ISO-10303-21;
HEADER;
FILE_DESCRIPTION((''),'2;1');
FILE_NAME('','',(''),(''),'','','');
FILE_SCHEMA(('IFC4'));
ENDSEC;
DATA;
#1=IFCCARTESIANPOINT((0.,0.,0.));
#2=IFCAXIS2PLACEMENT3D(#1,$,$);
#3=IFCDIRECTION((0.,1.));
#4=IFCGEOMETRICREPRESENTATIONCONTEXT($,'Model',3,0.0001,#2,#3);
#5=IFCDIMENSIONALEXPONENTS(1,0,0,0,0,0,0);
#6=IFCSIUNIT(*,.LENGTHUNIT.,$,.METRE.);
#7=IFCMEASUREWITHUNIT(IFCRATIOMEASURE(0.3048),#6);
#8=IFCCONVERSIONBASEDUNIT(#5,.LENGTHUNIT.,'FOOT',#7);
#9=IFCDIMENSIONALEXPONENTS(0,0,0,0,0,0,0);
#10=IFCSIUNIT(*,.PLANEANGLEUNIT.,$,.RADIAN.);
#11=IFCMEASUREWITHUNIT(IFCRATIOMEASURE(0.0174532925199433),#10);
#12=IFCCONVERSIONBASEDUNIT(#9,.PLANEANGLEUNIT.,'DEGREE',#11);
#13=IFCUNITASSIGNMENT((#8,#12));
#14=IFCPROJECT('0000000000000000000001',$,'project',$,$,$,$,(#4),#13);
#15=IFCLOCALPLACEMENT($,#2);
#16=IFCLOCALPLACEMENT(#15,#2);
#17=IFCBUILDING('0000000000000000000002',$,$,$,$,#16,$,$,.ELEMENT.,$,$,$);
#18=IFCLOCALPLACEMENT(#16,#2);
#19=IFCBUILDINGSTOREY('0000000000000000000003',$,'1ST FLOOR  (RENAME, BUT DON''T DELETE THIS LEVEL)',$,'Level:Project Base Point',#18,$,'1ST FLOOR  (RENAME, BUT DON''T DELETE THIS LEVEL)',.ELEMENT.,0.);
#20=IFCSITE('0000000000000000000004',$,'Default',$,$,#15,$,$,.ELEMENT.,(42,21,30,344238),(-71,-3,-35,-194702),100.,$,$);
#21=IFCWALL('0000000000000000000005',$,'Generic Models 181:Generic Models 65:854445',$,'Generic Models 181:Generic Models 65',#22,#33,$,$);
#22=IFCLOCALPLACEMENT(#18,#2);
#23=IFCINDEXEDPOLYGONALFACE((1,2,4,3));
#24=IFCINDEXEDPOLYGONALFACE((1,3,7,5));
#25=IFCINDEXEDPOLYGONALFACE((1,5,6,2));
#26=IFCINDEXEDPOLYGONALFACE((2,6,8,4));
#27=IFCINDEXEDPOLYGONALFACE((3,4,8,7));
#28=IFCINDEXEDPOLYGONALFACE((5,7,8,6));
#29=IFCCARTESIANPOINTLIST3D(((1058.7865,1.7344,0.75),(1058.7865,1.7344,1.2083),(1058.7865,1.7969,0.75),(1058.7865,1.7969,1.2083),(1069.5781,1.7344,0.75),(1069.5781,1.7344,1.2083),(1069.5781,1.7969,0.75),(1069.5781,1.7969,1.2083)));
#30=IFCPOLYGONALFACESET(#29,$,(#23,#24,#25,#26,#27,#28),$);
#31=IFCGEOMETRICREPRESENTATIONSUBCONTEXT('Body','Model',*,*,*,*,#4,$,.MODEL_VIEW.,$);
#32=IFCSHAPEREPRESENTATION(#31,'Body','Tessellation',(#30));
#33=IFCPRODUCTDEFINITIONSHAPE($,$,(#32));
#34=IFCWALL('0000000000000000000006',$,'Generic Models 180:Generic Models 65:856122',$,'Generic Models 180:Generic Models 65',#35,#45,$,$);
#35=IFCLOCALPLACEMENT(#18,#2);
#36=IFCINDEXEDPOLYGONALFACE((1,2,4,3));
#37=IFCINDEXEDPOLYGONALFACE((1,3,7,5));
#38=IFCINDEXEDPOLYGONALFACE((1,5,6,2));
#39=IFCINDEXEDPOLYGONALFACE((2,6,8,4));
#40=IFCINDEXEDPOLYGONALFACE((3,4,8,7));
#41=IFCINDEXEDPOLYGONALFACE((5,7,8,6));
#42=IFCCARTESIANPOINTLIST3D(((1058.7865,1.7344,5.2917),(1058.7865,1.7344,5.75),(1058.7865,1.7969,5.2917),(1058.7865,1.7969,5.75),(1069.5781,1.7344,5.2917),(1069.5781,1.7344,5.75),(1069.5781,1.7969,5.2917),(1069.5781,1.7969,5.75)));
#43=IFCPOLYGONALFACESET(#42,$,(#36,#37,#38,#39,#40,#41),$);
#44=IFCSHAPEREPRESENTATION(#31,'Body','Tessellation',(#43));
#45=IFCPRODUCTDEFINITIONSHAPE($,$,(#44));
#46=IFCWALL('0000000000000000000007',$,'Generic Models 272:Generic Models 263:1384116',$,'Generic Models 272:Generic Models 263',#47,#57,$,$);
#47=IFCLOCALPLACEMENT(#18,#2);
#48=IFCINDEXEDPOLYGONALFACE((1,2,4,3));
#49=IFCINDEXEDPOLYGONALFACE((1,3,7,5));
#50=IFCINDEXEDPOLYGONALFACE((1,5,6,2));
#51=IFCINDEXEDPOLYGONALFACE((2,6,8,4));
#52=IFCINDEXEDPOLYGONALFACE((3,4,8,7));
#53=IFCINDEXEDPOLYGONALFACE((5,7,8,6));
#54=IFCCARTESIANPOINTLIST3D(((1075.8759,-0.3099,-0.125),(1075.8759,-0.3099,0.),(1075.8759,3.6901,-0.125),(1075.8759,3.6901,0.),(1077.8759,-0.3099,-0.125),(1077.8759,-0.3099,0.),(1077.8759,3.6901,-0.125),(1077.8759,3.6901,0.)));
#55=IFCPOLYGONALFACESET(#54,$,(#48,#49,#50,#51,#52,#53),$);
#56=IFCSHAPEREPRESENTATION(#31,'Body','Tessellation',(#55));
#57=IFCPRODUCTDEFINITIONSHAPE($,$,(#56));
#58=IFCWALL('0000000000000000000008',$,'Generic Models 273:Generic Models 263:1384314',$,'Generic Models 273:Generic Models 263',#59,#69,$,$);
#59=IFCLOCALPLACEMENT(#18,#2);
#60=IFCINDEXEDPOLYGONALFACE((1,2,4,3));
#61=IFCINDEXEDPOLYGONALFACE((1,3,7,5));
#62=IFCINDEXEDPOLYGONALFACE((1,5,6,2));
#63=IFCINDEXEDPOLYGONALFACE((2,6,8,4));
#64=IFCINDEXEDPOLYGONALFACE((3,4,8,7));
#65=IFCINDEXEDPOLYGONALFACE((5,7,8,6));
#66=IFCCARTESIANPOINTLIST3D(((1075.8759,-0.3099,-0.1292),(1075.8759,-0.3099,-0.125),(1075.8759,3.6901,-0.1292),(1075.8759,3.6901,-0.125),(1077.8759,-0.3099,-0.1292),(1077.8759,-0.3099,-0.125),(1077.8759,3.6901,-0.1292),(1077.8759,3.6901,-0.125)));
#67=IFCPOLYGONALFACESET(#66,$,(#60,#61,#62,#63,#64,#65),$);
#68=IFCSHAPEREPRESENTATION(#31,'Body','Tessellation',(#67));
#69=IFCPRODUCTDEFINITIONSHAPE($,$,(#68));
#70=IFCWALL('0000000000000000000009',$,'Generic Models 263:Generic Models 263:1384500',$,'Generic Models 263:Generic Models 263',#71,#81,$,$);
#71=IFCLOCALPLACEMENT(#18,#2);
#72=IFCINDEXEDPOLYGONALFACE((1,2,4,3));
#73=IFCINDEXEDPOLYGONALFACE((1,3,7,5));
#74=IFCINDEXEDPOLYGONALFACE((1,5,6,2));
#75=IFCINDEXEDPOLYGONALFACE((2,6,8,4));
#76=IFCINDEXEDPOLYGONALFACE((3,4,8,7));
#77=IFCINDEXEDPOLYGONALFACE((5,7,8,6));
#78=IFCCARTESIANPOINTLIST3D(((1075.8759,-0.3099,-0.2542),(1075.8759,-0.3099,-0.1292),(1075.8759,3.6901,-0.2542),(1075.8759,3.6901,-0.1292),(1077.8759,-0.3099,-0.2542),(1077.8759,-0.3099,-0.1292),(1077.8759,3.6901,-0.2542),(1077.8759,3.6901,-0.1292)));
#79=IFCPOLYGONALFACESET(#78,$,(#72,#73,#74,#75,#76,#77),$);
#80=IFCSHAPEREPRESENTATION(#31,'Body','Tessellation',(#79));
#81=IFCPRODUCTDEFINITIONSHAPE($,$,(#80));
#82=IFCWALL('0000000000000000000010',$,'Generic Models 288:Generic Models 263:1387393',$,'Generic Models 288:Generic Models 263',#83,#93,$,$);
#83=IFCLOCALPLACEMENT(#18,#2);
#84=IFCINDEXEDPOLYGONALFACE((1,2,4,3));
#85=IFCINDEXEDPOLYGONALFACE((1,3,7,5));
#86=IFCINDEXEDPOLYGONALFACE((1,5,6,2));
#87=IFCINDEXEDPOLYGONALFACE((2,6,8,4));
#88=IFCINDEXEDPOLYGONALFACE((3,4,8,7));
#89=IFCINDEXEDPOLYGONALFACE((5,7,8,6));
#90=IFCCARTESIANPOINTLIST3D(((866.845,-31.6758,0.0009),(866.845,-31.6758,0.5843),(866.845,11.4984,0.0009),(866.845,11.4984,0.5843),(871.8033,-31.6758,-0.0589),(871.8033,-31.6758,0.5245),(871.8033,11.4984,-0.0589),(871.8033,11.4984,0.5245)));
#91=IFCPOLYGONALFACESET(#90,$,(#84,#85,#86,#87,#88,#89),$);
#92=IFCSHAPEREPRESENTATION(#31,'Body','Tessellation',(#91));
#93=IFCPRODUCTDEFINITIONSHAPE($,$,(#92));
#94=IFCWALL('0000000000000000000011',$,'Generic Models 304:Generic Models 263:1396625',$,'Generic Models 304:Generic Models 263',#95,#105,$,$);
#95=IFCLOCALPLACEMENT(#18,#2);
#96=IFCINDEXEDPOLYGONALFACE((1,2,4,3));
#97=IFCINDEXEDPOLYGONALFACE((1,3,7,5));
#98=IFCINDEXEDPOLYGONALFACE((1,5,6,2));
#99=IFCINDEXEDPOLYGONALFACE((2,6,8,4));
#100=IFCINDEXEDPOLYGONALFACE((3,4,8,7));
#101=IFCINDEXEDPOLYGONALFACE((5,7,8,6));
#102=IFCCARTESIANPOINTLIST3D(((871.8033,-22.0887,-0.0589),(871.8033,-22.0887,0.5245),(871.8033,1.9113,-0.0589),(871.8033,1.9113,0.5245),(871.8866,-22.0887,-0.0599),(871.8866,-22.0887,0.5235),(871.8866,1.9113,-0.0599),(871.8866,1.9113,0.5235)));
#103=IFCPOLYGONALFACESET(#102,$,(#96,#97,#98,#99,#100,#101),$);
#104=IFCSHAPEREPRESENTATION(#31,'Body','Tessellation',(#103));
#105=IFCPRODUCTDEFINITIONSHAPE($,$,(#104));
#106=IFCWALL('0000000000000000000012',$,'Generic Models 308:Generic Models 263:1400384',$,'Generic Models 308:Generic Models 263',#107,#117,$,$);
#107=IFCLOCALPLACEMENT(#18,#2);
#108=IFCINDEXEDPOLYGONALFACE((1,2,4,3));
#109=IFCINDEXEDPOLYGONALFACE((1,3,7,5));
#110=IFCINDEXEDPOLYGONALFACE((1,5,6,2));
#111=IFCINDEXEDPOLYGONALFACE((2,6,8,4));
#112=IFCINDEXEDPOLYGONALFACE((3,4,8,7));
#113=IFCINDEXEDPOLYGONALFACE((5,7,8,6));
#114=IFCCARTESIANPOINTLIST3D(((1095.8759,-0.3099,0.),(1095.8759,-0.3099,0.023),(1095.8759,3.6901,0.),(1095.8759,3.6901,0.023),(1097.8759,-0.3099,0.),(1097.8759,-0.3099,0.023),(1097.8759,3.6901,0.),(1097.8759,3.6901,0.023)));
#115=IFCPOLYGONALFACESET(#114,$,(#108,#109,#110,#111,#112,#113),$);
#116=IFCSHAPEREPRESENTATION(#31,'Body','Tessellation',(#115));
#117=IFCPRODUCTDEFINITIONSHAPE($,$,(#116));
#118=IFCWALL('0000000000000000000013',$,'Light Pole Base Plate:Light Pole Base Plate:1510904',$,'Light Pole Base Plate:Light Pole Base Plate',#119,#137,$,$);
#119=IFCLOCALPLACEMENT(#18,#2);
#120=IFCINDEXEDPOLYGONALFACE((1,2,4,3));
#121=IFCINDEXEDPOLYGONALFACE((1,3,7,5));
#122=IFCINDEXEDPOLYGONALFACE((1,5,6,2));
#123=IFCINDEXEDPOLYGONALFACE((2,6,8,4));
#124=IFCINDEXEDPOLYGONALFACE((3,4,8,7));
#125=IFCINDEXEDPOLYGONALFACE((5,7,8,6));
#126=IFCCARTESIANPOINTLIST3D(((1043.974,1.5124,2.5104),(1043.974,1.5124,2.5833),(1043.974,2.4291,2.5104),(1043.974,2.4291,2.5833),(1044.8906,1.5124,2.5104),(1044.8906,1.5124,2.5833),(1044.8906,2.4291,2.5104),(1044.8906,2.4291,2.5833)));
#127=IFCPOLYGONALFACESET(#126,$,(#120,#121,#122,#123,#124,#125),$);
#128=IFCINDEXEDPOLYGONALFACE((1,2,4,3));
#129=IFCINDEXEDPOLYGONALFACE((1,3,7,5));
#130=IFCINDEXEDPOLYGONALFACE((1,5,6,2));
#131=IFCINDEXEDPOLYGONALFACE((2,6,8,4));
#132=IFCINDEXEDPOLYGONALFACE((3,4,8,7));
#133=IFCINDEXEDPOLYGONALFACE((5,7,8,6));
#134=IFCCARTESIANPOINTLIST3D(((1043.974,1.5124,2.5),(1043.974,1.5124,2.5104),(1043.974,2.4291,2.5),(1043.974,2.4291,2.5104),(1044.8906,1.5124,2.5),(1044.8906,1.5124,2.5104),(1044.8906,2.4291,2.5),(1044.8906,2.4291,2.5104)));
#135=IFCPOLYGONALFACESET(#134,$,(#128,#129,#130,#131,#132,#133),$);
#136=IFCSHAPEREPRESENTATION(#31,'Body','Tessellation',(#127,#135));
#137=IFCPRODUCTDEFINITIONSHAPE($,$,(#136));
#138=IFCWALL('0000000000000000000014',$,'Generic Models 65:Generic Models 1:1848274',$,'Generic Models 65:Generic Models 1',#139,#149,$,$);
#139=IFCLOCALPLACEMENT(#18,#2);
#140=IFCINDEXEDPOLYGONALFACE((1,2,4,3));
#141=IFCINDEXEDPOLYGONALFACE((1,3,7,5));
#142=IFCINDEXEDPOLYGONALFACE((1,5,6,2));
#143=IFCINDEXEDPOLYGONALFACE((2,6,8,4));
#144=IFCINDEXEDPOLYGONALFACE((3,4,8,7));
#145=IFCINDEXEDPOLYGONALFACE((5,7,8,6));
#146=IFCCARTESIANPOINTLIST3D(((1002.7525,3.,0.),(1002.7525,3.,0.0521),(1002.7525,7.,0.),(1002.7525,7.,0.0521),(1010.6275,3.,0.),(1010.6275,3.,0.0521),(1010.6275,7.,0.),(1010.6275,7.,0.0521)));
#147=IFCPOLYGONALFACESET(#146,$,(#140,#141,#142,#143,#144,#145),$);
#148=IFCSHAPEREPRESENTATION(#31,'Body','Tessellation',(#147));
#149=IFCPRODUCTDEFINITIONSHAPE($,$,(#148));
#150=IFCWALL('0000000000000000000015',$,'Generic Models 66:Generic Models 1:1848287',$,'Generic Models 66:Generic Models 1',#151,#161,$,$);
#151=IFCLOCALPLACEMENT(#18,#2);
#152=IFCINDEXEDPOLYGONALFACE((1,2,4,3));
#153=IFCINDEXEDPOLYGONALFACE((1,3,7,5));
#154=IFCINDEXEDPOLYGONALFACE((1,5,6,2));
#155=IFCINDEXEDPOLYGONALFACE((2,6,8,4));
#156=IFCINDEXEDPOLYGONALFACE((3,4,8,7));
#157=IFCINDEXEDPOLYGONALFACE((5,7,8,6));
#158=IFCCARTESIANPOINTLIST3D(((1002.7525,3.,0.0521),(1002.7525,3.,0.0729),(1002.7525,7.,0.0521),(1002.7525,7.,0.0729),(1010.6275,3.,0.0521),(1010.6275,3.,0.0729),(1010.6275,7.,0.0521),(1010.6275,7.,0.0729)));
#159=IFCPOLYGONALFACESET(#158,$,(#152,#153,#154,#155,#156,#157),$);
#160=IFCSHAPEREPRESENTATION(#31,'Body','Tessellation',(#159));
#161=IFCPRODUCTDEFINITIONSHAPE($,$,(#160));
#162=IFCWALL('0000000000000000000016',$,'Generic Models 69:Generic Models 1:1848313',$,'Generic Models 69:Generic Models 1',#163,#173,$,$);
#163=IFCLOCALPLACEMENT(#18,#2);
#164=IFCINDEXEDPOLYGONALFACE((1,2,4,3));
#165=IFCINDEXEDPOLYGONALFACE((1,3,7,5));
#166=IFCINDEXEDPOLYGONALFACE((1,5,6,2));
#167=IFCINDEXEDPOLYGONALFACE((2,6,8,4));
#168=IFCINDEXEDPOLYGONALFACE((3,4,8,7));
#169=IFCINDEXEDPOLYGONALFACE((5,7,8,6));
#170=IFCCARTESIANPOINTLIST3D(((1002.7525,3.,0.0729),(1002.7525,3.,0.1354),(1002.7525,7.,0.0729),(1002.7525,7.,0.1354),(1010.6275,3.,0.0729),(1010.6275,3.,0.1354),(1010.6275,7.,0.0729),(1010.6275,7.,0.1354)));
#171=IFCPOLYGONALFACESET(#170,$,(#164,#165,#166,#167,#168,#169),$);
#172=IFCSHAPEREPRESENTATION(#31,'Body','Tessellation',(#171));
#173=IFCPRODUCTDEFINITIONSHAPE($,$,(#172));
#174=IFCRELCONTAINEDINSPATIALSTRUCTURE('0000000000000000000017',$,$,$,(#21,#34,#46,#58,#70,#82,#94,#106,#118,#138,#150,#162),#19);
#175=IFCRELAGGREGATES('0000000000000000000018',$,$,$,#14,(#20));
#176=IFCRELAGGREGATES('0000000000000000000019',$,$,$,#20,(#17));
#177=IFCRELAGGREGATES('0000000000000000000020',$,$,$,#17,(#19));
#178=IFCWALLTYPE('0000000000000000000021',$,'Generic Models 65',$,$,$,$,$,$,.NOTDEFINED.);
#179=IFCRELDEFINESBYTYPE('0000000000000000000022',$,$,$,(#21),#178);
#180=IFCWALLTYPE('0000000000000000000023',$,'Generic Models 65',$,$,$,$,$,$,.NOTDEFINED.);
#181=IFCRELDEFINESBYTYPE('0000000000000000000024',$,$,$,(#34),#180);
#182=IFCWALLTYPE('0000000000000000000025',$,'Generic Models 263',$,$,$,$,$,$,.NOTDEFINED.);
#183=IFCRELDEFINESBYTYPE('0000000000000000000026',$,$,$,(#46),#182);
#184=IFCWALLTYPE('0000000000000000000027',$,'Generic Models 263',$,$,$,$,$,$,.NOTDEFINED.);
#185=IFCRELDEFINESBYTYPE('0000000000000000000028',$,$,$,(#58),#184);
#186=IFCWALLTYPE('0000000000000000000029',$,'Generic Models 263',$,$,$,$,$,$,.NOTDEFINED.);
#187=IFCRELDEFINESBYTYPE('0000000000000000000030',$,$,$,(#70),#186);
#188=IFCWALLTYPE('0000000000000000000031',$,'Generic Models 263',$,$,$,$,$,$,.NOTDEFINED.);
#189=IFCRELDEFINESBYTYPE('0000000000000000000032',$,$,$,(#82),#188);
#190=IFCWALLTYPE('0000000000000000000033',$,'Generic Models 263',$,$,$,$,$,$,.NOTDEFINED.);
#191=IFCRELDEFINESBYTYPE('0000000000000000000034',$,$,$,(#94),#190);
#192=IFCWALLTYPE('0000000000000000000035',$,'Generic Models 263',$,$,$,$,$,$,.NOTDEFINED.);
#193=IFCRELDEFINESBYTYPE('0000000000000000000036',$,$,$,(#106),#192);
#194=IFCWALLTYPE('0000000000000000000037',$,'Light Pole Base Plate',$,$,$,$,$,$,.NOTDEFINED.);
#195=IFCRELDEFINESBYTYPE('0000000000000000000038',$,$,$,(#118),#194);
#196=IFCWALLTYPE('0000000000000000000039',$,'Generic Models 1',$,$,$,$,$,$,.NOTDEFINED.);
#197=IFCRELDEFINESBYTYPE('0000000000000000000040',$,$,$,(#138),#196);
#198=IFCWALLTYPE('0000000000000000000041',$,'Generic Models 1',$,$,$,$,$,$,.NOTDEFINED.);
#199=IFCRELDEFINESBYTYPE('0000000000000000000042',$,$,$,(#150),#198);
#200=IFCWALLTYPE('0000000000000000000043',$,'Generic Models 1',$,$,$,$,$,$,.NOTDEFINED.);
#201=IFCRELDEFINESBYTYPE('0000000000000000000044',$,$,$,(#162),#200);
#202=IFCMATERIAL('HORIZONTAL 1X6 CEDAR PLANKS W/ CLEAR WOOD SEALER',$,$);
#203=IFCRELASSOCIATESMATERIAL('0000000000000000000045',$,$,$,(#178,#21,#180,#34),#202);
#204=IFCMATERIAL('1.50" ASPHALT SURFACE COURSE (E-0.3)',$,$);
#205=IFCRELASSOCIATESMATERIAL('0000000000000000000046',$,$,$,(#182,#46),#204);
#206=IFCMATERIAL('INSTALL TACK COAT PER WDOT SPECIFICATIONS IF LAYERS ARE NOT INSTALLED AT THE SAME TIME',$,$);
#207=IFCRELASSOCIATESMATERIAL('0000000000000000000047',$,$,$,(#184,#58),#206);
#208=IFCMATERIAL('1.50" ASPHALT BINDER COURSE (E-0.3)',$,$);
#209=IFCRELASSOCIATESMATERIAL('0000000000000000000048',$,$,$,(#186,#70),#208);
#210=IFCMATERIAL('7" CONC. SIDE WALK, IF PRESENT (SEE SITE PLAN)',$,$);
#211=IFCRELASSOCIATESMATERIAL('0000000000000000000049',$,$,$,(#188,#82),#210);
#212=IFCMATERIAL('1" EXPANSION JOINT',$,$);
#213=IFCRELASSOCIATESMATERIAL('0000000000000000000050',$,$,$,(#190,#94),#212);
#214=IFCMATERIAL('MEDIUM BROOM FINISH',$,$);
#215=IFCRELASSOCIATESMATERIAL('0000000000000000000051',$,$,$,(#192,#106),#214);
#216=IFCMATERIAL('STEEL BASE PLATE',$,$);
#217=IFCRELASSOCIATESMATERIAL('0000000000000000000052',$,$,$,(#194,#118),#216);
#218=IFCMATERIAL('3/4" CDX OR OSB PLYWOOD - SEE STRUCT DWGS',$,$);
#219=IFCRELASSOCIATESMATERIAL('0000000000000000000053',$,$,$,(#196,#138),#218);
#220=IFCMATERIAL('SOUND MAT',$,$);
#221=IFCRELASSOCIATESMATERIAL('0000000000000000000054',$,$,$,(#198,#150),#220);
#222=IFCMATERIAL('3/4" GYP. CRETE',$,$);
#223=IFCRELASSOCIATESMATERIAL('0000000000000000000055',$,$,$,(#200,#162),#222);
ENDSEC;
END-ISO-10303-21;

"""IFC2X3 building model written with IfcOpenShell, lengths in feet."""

from ifc_helpers import new_model, entity, si_unit, converted_unit, direction, frame, frame_2d, origin, origin_2d_with_axis, place, context, subcontext, project, spatial, rectangle, extrude, material, type_object, element, save


model = new_model("IFC2X3")

# Units and contexts
model_context = context("Model", 3, precision=0.0001, world=origin(), true_north=direction((0.0, 1.0)))
body_context = subcontext(model_context, "Body", "Model", "MODEL_VIEW")
ifc_project = project(units=[converted_unit("LENGTHUNIT", "FOOT", entity("IfcRatioMeasure", 0.3048), si_unit("LENGTHUNIT", "METRE"), dimensions=[1, 0, 0, 0, 0, 0, 0]), converted_unit("PLANEANGLEUNIT", "DEGREE", entity("IfcRatioMeasure", 0.0174532925199433), si_unit("PLANEANGLEUNIT", "RADIAN"), dimensions=[0, 0, 0, 0, 0, 0, 0])], contexts=[model_context])

# Site, building, storey
site_placement = place(None, origin())
site = spatial("IfcSite", under=ifc_project, at=site_placement, Name="Default", CompositionType="ELEMENT", RefLatitude=(42, 21, 30, 344238), RefLongitude=(-71, -3, -35, -194702), RefElevation=100.0)
building_placement = place(site_placement, origin())
building = spatial("IfcBuilding", under=site, at=building_placement, CompositionType="ELEMENT")
storey_placement = place(building_placement, origin())
storey = spatial("IfcBuildingStorey", under=building, at=storey_placement, Name="1ST FLOOR  (RENAME, BUT DON'T DELETE THIS LEVEL)", ObjectType="Level:Project Base Point", LongName="1ST FLOOR  (RENAME, BUT DON'T DELETE THIS LEVEL)", CompositionType="ELEMENT", Elevation=0.0)

# Walls
ifc_material_1 = material(Name="HORIZONTAL 1X6 CEDAR PLANKS W/ CLEAR WOOD SEALER")
wall_type_1 = type_object("IfcWallType", Name="Generic Models 65", PredefinedType="NOTDEFINED", material=ifc_material_1)
wall_1_placement = place(storey_placement, frame((1058.7865, 1.7344, 0.75)))
element("IfcWall", 1, at=wall_1_placement, inside=storey, type_object=wall_type_1, material=ifc_material_1, Name="Generic Models 181:Generic Models 65:854445", ObjectType="Generic Models 181:Generic Models 65", context=body_context, shape_type="SweptSolid", body=[
    extrude(rectangle(XDim=10.7917, YDim=0.0625, at=frame_2d((0.0, 0.0), x_axis=(1.0, 0.0))), frame((5.3958, 0.0313, 0.0)), (0.0, 0.0, 1.0), 0.4583),
])
wall_type_2 = type_object("IfcWallType", Name="Generic Models 65", PredefinedType="NOTDEFINED", material=ifc_material_1)
wall_2_placement = place(storey_placement, frame((1058.7865, 1.7344, 5.2917)))
element("IfcWall", 2, at=wall_2_placement, inside=storey, type_object=wall_type_2, material=ifc_material_1, Name="Generic Models 180:Generic Models 65:856122", ObjectType="Generic Models 180:Generic Models 65", context=body_context, shape_type="SweptSolid", body=[
    extrude(rectangle(XDim=10.7917, YDim=0.0625, at=frame_2d((0.0, 0.0), x_axis=(1.0, 0.0))), frame((5.3958, 0.0313, 0.0)), (0.0, 0.0, 1.0), 0.4583),
])
ifc_material_2 = material(Name="1.50\" ASPHALT SURFACE COURSE (E-0.3)")
wall_type_3 = type_object("IfcWallType", Name="Generic Models 263", PredefinedType="NOTDEFINED", material=ifc_material_2)
wall_3_placement = place(storey_placement, frame((1075.8759, -0.3099, -0.125), z_axis=(0.0, 0.0, 1.0), x_axis=(0.0, 1.0, 0.0)))
element("IfcWall", 3, at=wall_3_placement, inside=storey, type_object=wall_type_3, material=ifc_material_2, Name="Generic Models 272:Generic Models 263:1384116", ObjectType="Generic Models 272:Generic Models 263", context=body_context, shape_type="SweptSolid", body=[
    extrude(rectangle(XDim=4.0, YDim=2.0, at=origin_2d_with_axis()), frame((2.0, -1.0, 0.0)), (0.0, 0.0, 1.0), 0.125),
])
ifc_material_3 = material(Name="INSTALL TACK COAT PER WDOT SPECIFICATIONS IF LAYERS ARE NOT INSTALLED AT THE SAME TIME")
wall_type_4 = type_object("IfcWallType", Name="Generic Models 263", PredefinedType="NOTDEFINED", material=ifc_material_3)
wall_4_placement = place(storey_placement, frame((1075.8759, -0.3099, -0.1292), z_axis=(0.0, 0.0, 1.0), x_axis=(0.0, 1.0, 0.0)))
element("IfcWall", 4, at=wall_4_placement, inside=storey, type_object=wall_type_4, material=ifc_material_3, Name="Generic Models 273:Generic Models 263:1384314", ObjectType="Generic Models 273:Generic Models 263", context=body_context, shape_type="SweptSolid", body=[
    extrude(rectangle(XDim=4.0, YDim=2.0, at=origin_2d_with_axis()), frame((2.0, -1.0, 0.0)), (0.0, 0.0, 1.0), 0.0042),
])
ifc_material_4 = material(Name="1.50\" ASPHALT BINDER COURSE (E-0.3)")
wall_type_5 = type_object("IfcWallType", Name="Generic Models 263", PredefinedType="NOTDEFINED", material=ifc_material_4)
wall_5_placement = place(storey_placement, frame((1075.8759, -0.3099, -0.2542), z_axis=(0.0, 0.0, 1.0), x_axis=(0.0, 1.0, 0.0)))
element("IfcWall", 5, at=wall_5_placement, inside=storey, type_object=wall_type_5, material=ifc_material_4, Name="Generic Models 263:Generic Models 263:1384500", ObjectType="Generic Models 263:Generic Models 263", context=body_context, shape_type="SweptSolid", body=[
    extrude(rectangle(XDim=4.0, YDim=2.0, at=origin_2d_with_axis()), frame((2.0, -1.0, 0.0)), (0.0, 0.0, 1.0), 0.125),
])
ifc_material_5 = material(Name="7\" CONC. SIDE WALK, IF PRESENT (SEE SITE PLAN)")
wall_type_6 = type_object("IfcWallType", Name="Generic Models 263", PredefinedType="NOTDEFINED", material=ifc_material_5)
wall_6_placement = place(storey_placement, frame((866.845, -31.6758, -0.0589), z_axis=(0.0, 0.0, 1.0), x_axis=(0.0, 1.0, 0.0)))
element("IfcWall", 6, at=wall_6_placement, inside=storey, type_object=wall_type_6, material=ifc_material_5, Name="Generic Models 288:Generic Models 263:1387393", ObjectType="Generic Models 288:Generic Models 263", context=body_context, shape_type="SweptSolid", body=[
    extrude(rectangle(XDim=4.9587, YDim=43.1742, at=frame_2d((0.0, 0.0), x_axis=(0.0, 1.0))), frame((21.5871, -2.4792, 0.0299), z_axis=(0.0, -0.012064, 0.999927), x_axis=(1.0, 0.0, 0.0)), (0.0, 0.012064, 0.999927), 0.5834),
])
ifc_material_6 = material(Name="1\" EXPANSION JOINT")
wall_type_7 = type_object("IfcWallType", Name="Generic Models 263", PredefinedType="NOTDEFINED", material=ifc_material_6)
wall_7_placement = place(storey_placement, frame((871.8033, -22.0887, -0.0599), z_axis=(0.0, 0.0, 1.0), x_axis=(0.0, 1.0, 0.0)))
element("IfcWall", 7, at=wall_7_placement, inside=storey, type_object=wall_type_7, material=ifc_material_6, Name="Generic Models 304:Generic Models 263:1396625", ObjectType="Generic Models 304:Generic Models 263", context=body_context, shape_type="SweptSolid", body=[
    extrude(rectangle(XDim=0.0833, YDim=24.0, at=frame_2d((0.0, 0.0), x_axis=(0.0, 1.0))), frame((12.0, -0.0417, 0.0005), z_axis=(0.0, -0.012064, 0.999927), x_axis=(1.0, 0.0, 0.0)), (0.0, 0.012064, 0.999927), 0.5834),
])
ifc_material_7 = material(Name="MEDIUM BROOM FINISH")
wall_type_8 = type_object("IfcWallType", Name="Generic Models 263", PredefinedType="NOTDEFINED", material=ifc_material_7)
wall_8_placement = place(storey_placement, frame((1095.8759, -0.3099, 0.0), z_axis=(0.0, 0.0, 1.0), x_axis=(0.0, 1.0, 0.0)))
element("IfcWall", 8, at=wall_8_placement, inside=storey, type_object=wall_type_8, material=ifc_material_7, Name="Generic Models 308:Generic Models 263:1400384", ObjectType="Generic Models 308:Generic Models 263", context=body_context, shape_type="SweptSolid", body=[
    extrude(rectangle(XDim=4.0, YDim=2.0, at=origin_2d_with_axis()), frame((2.0, -1.0, 0.0)), (0.0, 0.0, 1.0), 0.023),
])
ifc_material_8 = material(Name="STEEL BASE PLATE")
wall_type_9 = type_object("IfcWallType", Name="Light Pole Base Plate", PredefinedType="NOTDEFINED", material=ifc_material_8)
wall_9_placement = place(storey_placement, frame((1043.974, 1.5124, 2.5), z_axis=(0.0, 0.0, 1.0), x_axis=(0.0, 1.0, 0.0)))
element("IfcWall", 9, at=wall_9_placement, inside=storey, type_object=wall_type_9, material=ifc_material_8, Name="Light Pole Base Plate:Light Pole Base Plate:1510904", ObjectType="Light Pole Base Plate:Light Pole Base Plate", context=body_context, shape_type="SweptSolid", body=[
    extrude(rectangle(XDim=0.9167, YDim=0.9167, at=frame_2d((0.0, 0.0), x_axis=(1.0, 0.0))), frame((0.4583, -0.4583, 0.0104), z_axis=(0.0, 0.0, 1.0), x_axis=(-1.0, 0.0, 0.0)), (0.0, 0.0, 1.0), 0.0729),
    extrude(rectangle(XDim=0.9167, YDim=0.9167, at=frame_2d((0.0, 0.0), x_axis=(1.0, 0.0))), frame((0.4583, -0.4583, 0.0), z_axis=(0.0, 0.0, 1.0), x_axis=(-1.0, 0.0, 0.0)), (0.0, 0.0, 1.0), 0.0104),
])
ifc_material_9 = material(Name="3/4\" CDX OR OSB PLYWOOD - SEE STRUCT DWGS")
wall_type_10 = type_object("IfcWallType", Name="Generic Models 1", PredefinedType="NOTDEFINED", material=ifc_material_9)
wall_10_placement = place(storey_placement, frame((1002.7525, 3.0, 0.0)))
element("IfcWall", 10, at=wall_10_placement, inside=storey, type_object=wall_type_10, material=ifc_material_9, Name="Generic Models 65:Generic Models 1:1848274", ObjectType="Generic Models 65:Generic Models 1", context=body_context, shape_type="SweptSolid", body=[
    extrude(rectangle(XDim=4.0, YDim=7.875, at=frame_2d((0.0, 0.0), x_axis=(1.0, 0.0))), frame((3.9375, 2.0, 0.0), z_axis=(0.0, 0.0, 1.0), x_axis=(0.0, 1.0, 0.0)), (0.0, 0.0, 1.0), 0.0521),
])
ifc_material_10 = material(Name="SOUND MAT")
wall_type_11 = type_object("IfcWallType", Name="Generic Models 1", PredefinedType="NOTDEFINED", material=ifc_material_10)
wall_11_placement = place(storey_placement, frame((1002.7525, 3.0, 0.0521)))
element("IfcWall", 11, at=wall_11_placement, inside=storey, type_object=wall_type_11, material=ifc_material_10, Name="Generic Models 66:Generic Models 1:1848287", ObjectType="Generic Models 66:Generic Models 1", context=body_context, shape_type="SweptSolid", body=[
    extrude(rectangle(XDim=4.0, YDim=7.875, at=frame_2d((0.0, 0.0), x_axis=(1.0, 0.0))), frame((3.9375, 2.0, 0.0), z_axis=(0.0, 0.0, 1.0), x_axis=(0.0, 1.0, 0.0)), (0.0, 0.0, 1.0), 0.0208),
])
ifc_material_11 = material(Name="3/4\" GYP. CRETE")
wall_type_12 = type_object("IfcWallType", Name="Generic Models 1", PredefinedType="NOTDEFINED", material=ifc_material_11)
wall_12_placement = place(storey_placement, frame((1002.7525, 3.0, 0.0729)))
element("IfcWall", 12, at=wall_12_placement, inside=storey, type_object=wall_type_12, material=ifc_material_11, Name="Generic Models 69:Generic Models 1:1848313", ObjectType="Generic Models 69:Generic Models 1", context=body_context, shape_type="SweptSolid", body=[
    extrude(rectangle(XDim=4.0, YDim=7.875, at=frame_2d((0.0, 0.0), x_axis=(1.0, 0.0))), frame((3.9375, 2.0, 0.0), z_axis=(0.0, 0.0, 1.0), x_axis=(0.0, 1.0, 0.0)), (0.0, 0.0, 1.0), 0.0625),
])

save(model, "model.ifc")
